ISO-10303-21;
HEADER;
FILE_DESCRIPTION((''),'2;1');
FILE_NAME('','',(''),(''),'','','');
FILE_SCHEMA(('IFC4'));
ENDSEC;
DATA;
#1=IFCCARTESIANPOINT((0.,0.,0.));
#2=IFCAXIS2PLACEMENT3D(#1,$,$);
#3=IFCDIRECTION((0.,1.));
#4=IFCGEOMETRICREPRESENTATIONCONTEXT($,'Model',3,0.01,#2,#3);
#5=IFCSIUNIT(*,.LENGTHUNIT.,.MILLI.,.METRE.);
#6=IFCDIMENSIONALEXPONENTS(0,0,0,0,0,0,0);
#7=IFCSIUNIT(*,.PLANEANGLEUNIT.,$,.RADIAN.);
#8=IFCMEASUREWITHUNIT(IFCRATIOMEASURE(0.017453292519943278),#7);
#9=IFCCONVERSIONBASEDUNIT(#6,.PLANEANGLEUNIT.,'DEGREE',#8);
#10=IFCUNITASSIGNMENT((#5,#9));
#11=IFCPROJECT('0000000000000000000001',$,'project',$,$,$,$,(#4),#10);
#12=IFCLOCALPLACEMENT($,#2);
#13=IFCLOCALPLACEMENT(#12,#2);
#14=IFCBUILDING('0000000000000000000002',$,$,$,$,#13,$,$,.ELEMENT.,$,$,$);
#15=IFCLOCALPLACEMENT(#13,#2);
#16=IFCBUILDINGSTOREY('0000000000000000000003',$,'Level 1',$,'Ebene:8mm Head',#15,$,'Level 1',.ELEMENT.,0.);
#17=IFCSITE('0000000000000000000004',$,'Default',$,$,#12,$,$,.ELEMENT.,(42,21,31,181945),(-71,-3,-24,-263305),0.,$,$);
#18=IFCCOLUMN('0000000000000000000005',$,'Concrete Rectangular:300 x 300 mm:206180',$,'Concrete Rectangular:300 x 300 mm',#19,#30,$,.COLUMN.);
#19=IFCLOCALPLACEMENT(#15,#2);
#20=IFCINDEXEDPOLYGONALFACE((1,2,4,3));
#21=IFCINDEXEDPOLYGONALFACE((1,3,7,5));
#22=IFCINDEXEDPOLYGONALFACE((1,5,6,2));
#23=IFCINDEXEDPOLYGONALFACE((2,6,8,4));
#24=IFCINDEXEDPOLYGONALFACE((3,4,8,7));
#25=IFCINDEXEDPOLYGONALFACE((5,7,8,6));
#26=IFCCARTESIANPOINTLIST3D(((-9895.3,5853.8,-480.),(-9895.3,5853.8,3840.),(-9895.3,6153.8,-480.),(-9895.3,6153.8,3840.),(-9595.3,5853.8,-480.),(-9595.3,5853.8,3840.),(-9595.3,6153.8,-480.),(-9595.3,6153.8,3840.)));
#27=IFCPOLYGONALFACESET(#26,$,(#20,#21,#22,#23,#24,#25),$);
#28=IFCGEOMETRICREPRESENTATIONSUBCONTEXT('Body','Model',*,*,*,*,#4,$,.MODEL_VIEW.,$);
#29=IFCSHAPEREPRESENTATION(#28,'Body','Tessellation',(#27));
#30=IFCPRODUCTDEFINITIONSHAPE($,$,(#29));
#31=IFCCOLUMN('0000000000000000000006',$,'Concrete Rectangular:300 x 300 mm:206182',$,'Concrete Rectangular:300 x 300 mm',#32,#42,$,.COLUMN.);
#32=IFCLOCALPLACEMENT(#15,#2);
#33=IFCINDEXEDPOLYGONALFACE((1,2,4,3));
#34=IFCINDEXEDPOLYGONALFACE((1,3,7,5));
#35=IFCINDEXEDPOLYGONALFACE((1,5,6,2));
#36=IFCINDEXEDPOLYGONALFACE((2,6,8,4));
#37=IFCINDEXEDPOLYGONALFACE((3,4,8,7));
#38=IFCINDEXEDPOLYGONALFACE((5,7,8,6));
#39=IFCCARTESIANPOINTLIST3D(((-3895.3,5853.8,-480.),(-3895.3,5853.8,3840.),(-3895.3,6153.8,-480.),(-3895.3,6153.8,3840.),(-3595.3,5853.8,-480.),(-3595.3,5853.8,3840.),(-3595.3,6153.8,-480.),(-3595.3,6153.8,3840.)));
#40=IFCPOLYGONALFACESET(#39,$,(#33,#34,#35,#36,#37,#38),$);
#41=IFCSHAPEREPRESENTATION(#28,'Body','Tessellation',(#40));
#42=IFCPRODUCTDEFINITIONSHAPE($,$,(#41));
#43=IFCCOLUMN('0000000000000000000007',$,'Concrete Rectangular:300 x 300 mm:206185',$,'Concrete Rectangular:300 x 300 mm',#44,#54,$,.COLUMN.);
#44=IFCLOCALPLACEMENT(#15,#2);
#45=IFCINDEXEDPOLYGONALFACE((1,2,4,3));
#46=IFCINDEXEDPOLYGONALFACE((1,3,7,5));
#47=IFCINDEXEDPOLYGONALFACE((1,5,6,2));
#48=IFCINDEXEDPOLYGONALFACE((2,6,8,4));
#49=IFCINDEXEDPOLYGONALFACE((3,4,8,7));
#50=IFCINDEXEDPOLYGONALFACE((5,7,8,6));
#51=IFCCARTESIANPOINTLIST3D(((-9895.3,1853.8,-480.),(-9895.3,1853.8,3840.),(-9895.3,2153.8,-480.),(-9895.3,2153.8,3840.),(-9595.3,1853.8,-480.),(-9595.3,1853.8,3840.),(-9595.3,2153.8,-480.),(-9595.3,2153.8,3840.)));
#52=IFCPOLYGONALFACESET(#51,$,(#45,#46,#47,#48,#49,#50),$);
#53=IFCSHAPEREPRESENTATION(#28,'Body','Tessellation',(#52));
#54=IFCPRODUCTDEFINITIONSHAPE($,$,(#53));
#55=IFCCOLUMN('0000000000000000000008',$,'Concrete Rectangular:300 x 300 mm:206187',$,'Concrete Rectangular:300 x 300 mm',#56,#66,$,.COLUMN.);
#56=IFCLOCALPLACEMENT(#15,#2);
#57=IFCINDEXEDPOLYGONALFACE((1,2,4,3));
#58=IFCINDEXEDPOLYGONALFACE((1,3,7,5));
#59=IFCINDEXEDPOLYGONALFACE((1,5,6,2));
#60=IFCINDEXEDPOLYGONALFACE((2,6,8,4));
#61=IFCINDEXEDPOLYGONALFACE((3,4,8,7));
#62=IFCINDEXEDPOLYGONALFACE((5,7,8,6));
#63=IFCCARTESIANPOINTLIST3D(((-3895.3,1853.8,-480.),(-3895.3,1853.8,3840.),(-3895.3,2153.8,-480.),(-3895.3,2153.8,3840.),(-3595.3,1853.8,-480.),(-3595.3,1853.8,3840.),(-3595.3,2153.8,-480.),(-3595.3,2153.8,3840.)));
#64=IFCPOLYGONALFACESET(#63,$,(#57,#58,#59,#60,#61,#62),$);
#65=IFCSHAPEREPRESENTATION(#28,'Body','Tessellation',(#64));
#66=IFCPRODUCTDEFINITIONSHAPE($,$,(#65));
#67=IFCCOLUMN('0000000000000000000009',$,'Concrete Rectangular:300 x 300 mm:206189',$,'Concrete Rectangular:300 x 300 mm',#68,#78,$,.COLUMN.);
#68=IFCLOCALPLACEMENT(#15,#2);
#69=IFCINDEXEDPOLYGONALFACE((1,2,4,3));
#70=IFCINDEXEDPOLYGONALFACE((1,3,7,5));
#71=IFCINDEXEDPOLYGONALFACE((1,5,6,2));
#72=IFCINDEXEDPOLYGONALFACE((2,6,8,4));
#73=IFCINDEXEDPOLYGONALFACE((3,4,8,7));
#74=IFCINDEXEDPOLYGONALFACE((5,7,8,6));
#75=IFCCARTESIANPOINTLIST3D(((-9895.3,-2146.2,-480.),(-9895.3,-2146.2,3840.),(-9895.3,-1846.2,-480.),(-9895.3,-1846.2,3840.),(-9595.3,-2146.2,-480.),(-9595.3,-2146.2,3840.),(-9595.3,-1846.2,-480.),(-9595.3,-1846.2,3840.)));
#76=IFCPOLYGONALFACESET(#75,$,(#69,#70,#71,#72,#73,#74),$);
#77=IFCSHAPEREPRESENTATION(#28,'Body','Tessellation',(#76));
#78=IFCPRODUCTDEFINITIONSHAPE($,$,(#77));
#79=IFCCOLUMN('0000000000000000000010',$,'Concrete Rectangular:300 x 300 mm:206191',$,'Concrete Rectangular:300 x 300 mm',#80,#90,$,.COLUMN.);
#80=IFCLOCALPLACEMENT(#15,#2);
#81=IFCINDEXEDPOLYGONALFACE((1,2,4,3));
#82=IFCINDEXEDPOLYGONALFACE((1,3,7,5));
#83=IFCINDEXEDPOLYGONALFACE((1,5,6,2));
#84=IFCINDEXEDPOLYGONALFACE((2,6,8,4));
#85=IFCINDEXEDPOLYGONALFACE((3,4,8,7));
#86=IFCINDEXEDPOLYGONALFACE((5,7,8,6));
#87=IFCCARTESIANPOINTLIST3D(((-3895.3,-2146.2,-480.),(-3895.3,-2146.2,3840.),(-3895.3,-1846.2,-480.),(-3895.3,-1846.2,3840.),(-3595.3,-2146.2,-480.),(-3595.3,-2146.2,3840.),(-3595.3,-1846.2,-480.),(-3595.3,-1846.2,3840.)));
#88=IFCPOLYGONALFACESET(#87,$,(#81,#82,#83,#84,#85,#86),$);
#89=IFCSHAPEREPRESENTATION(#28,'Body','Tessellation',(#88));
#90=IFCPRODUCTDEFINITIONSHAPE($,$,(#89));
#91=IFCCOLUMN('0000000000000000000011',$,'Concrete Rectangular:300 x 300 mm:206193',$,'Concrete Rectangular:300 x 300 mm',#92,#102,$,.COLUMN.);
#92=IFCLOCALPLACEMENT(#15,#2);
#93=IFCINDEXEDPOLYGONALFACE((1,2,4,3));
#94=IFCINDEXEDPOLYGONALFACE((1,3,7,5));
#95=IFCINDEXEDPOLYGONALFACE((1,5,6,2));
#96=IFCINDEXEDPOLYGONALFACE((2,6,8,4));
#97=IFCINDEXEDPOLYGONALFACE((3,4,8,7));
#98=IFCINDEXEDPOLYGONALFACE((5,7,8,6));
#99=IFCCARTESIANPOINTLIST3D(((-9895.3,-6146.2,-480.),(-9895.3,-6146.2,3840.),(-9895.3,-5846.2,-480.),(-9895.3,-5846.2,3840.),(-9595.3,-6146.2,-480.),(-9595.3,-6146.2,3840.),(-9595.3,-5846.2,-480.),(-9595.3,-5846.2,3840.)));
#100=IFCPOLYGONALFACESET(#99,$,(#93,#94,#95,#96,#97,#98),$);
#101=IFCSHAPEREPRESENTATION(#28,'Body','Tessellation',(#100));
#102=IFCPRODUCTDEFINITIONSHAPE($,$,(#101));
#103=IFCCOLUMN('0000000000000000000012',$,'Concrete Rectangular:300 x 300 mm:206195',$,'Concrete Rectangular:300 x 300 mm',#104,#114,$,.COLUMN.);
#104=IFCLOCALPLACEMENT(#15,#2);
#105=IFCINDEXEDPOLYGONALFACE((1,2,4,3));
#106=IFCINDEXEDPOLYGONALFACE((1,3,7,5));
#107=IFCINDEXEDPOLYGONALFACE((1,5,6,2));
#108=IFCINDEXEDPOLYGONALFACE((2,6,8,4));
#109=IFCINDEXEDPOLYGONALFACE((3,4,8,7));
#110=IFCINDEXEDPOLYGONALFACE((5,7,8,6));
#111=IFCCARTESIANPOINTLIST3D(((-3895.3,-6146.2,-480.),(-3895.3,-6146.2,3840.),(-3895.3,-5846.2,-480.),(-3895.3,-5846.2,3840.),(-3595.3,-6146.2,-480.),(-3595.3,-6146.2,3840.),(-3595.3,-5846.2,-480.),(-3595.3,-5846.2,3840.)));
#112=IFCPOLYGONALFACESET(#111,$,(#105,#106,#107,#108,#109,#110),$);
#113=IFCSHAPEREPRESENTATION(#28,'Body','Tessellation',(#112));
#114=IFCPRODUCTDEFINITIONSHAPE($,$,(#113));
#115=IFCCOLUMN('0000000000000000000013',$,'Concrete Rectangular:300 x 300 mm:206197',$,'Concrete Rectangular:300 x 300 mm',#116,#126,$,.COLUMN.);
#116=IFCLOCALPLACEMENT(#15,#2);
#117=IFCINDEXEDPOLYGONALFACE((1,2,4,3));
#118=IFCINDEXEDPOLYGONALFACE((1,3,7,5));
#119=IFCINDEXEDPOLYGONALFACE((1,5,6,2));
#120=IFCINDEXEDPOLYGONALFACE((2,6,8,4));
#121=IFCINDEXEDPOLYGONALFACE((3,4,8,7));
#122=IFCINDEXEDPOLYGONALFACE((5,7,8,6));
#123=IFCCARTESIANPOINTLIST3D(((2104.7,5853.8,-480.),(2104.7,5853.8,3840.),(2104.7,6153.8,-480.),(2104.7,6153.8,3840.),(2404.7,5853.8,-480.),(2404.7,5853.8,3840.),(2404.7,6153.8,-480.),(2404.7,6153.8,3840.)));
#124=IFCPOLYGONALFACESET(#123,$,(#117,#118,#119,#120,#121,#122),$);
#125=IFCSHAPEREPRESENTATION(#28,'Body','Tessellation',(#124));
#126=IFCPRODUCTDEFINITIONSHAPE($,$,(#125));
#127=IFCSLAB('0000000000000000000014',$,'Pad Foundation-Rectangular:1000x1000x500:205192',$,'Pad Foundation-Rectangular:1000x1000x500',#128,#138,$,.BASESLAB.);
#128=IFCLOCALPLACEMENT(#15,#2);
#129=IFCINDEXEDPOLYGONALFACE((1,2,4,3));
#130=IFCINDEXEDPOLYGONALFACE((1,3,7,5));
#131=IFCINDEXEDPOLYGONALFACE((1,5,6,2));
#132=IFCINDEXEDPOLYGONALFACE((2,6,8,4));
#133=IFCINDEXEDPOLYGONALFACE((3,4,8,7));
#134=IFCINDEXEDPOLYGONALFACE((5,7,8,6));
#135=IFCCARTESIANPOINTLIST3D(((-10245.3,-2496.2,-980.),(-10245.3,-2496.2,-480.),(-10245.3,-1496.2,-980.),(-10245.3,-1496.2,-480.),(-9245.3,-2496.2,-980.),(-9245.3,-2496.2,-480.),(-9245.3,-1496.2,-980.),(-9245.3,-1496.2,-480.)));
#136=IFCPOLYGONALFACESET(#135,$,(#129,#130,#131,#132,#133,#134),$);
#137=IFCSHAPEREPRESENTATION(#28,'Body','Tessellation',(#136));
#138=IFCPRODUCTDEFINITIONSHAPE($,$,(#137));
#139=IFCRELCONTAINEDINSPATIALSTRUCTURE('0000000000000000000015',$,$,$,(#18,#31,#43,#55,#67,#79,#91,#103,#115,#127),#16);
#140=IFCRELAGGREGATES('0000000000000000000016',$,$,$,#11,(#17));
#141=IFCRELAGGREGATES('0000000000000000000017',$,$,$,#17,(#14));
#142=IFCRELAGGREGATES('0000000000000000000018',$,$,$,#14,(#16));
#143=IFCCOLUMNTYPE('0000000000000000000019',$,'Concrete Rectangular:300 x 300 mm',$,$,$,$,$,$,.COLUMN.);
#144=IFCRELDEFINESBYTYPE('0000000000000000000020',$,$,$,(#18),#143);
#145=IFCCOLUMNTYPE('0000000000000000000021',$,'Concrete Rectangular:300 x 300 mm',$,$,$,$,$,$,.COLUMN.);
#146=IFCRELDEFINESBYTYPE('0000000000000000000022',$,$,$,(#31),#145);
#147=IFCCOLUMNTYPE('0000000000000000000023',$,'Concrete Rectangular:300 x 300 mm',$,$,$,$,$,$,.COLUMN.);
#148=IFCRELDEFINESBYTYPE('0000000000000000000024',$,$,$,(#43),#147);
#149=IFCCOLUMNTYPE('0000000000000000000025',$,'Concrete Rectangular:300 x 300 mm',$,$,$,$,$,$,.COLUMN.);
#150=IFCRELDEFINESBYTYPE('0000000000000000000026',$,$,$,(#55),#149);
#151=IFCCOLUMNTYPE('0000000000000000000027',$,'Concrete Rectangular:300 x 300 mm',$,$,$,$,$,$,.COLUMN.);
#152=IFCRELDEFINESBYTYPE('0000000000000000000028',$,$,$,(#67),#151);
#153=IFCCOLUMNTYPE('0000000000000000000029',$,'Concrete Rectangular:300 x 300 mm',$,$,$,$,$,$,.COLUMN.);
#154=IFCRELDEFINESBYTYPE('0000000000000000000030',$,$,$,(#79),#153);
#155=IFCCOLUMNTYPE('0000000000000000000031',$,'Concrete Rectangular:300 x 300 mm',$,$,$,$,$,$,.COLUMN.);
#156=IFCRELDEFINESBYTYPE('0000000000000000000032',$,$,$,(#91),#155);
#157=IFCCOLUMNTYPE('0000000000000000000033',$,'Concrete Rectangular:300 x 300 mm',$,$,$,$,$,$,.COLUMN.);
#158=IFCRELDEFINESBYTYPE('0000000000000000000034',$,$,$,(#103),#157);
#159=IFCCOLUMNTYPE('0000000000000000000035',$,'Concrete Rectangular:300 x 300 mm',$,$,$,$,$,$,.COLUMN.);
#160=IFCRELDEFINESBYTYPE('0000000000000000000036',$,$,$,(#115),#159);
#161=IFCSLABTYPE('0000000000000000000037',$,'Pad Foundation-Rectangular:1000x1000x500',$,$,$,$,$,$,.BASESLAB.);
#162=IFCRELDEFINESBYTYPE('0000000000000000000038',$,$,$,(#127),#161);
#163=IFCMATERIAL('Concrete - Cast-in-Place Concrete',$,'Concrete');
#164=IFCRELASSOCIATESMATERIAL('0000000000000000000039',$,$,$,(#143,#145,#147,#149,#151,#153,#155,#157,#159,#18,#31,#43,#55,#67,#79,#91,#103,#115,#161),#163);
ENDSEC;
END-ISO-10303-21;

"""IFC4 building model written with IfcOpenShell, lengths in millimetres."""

from ifc_helpers import new_model, entity, si_unit, converted_unit, direction, frame, frame_2d, origin, origin_2d_with_axis, place, context, subcontext, project, spatial, polyline, segment, composite_curve, rectangle, outline, extrude, source, transform, mapped, material, material_profile, profile_set, profile_usage, type_object, type_shapes, element, save


model = new_model("IFC4")

# Units and contexts
model_context = context("Model", 3, precision=0.01, world=origin(), true_north=direction((0.0, 1.0)))
body_context = subcontext(model_context, "Body", "Model", "MODEL_VIEW")
ifc_project = project(units=[si_unit("LENGTHUNIT", "METRE", prefix="MILLI"), converted_unit("PLANEANGLEUNIT", "DEGREE", entity("IfcRatioMeasure", 0.017453292519943278), si_unit("PLANEANGLEUNIT", "RADIAN"), dimensions=[0, 0, 0, 0, 0, 0, 0])], contexts=[model_context])

# Site, building, storey
site_placement = place(None, origin())
site = spatial("IfcSite", under=ifc_project, at=site_placement, Name="Default", CompositionType="ELEMENT", RefLatitude=(42, 21, 31, 181945), RefLongitude=(-71, -3, -24, -263305), RefElevation=0.0)
building_placement = place(site_placement, origin())
building = spatial("IfcBuilding", under=site, at=building_placement, CompositionType="ELEMENT")
storey_placement = place(building_placement, origin())
storey = spatial("IfcBuildingStorey", under=building, at=storey_placement, Name="Level 1", ObjectType="Ebene:8mm Head", LongName="Level 1", CompositionType="ELEMENT", Elevation=0.0)

# Columns
ifc_material_1 = material(Name="Concrete - Cast-in-Place Concrete", Category="Concrete")
ifc_material_profile_1 = material_profile(ifc_material_1, outline(composite_curve([segment(polyline([(150.0, 150.0, 0.0), (150.0, -150.0, 0.0)]), True, "CONTINUOUS"), segment(polyline([(150.0, -150.0, 0.0), (-150.0, -150.0, 0.0)]), True, "CONTINUOUS"), segment(polyline([(-150.0, -150.0, 0.0), (-150.0, 150.0, 0.0)]), True, "CONTINUOUS"), segment(polyline([(-150.0, 150.0, 0.0), (150.0, 150.0, 0.0)]), True, "CONTINUOUS")], self_intersect=False), kind="CURVE"), Name="300 x 300 mm")
ifc_material_profile_2 = material_profile(ifc_material_1, outline(composite_curve([segment(polyline([(150.0, 150.0, 4000.0), (-150.0, 150.0, 4000.0)]), True, "CONTINUOUS"), segment(polyline([(-150.0, 150.0, 4000.0), (-150.0, -150.0, 4000.0)]), True, "CONTINUOUS"), segment(polyline([(-150.0, -150.0, 4000.0), (150.0, -150.0, 4000.0)]), True, "CONTINUOUS"), segment(polyline([(150.0, -150.0, 4000.0), (150.0, 150.0, 4000.0)]), True, "CONTINUOUS")], self_intersect=False), kind="CURVE"), Name="300 x 300 mm")
ifc_profile_set = profile_set([ifc_material_profile_1, ifc_material_profile_2], Name="300 x 300 mm")
ifc_profile_usage_1 = profile_usage(ifc_profile_set)
column_type_1 = type_object("IfcColumnType", Name="Concrete Rectangular:300 x 300 mm", PredefinedType="COLUMN", material=ifc_profile_set)
shared_shape_1 = source(origin(), body_context, "Body", "SweptSolid", [
    extrude(rectangle(XDim=300.0, YDim=300.0, at=frame_2d((0.0, 0.0), x_axis=(1.0, 0.0))), frame((-9745.3, 6003.8, -480.0), z_axis=(0.0, 0.0, 1.0), x_axis=(0.0, -1.0, 0.0)), (0.0, 0.0, 1.0), 4320.0),
])
type_shapes(column_type_1, [shared_shape_1])
column_1_placement = place(storey_placement, origin())
element("IfcColumn", 1, at=column_1_placement, inside=storey, type_object=column_type_1, material=ifc_profile_usage_1, Name="Concrete Rectangular:300 x 300 mm:206180", ObjectType="Concrete Rectangular:300 x 300 mm", PredefinedType="COLUMN", context=body_context, shape_type="MappedRepresentation", body=[
    mapped(shared_shape_1, transform((0.0, 0.0, 0.0), scale=1.0)),
])
ifc_profile_usage_2 = profile_usage(ifc_profile_set)
column_type_2 = type_object("IfcColumnType", Name="Concrete Rectangular:300 x 300 mm", PredefinedType="COLUMN", material=ifc_profile_set)
shared_shape_2 = source(origin(), body_context, "Body", "SweptSolid", [
    extrude(rectangle(XDim=300.0, YDim=300.0, at=frame_2d((0.0, 0.0), x_axis=(1.0, 0.0))), frame((-3745.3, 6003.8, -480.0), z_axis=(0.0, 0.0, 1.0), x_axis=(0.0, -1.0, 0.0)), (0.0, 0.0, 1.0), 4320.0),
])
type_shapes(column_type_2, [shared_shape_2])
column_2_placement = place(storey_placement, origin())
element("IfcColumn", 2, at=column_2_placement, inside=storey, type_object=column_type_2, material=ifc_profile_usage_2, Name="Concrete Rectangular:300 x 300 mm:206182", ObjectType="Concrete Rectangular:300 x 300 mm", PredefinedType="COLUMN", context=body_context, shape_type="MappedRepresentation", body=[
    mapped(shared_shape_2, transform((0.0, 0.0, 0.0), scale=1.0)),
])
ifc_profile_usage_3 = profile_usage(ifc_profile_set)
column_type_3 = type_object("IfcColumnType", Name="Concrete Rectangular:300 x 300 mm", PredefinedType="COLUMN", material=ifc_profile_set)
shared_shape_3 = source(origin(), body_context, "Body", "SweptSolid", [
    extrude(rectangle(XDim=300.0, YDim=300.0, at=frame_2d((0.0, 0.0), x_axis=(1.0, 0.0))), frame((-9745.3, 2003.8, -480.0), z_axis=(0.0, 0.0, 1.0), x_axis=(0.0, -1.0, 0.0)), (0.0, 0.0, 1.0), 4320.0),
])
type_shapes(column_type_3, [shared_shape_3])
column_3_placement = place(storey_placement, origin())
element("IfcColumn", 3, at=column_3_placement, inside=storey, type_object=column_type_3, material=ifc_profile_usage_3, Name="Concrete Rectangular:300 x 300 mm:206185", ObjectType="Concrete Rectangular:300 x 300 mm", PredefinedType="COLUMN", context=body_context, shape_type="MappedRepresentation", body=[
    mapped(shared_shape_3, transform((0.0, 0.0, 0.0), scale=1.0)),
])
ifc_profile_usage_4 = profile_usage(ifc_profile_set)
column_type_4 = type_object("IfcColumnType", Name="Concrete Rectangular:300 x 300 mm", PredefinedType="COLUMN", material=ifc_profile_set)
shared_shape_4 = source(origin(), body_context, "Body", "SweptSolid", [
    extrude(rectangle(XDim=300.0, YDim=300.0, at=origin_2d_with_axis()), frame((-3745.3, 2003.8, -480.0), z_axis=(0.0, 0.0, 1.0), x_axis=(0.0, -1.0, 0.0)), (0.0, 0.0, 1.0), 4320.0),
])
type_shapes(column_type_4, [shared_shape_4])
column_4_placement = place(storey_placement, origin())
element("IfcColumn", 4, at=column_4_placement, inside=storey, type_object=column_type_4, material=ifc_profile_usage_4, Name="Concrete Rectangular:300 x 300 mm:206187", ObjectType="Concrete Rectangular:300 x 300 mm", PredefinedType="COLUMN", context=body_context, shape_type="MappedRepresentation", body=[
    mapped(shared_shape_4, transform((0.0, 0.0, 0.0), scale=1.0)),
])
ifc_profile_usage_5 = profile_usage(ifc_profile_set)
column_type_5 = type_object("IfcColumnType", Name="Concrete Rectangular:300 x 300 mm", PredefinedType="COLUMN", material=ifc_profile_set)
shared_shape_5 = source(origin(), body_context, "Body", "SweptSolid", [
    extrude(rectangle(XDim=300.0, YDim=300.0, at=frame_2d((0.0, 0.0), x_axis=(1.0, 0.0))), frame((-9745.3, -1996.2, -480.0), z_axis=(0.0, 0.0, 1.0), x_axis=(0.0, -1.0, 0.0)), (0.0, 0.0, 1.0), 4320.0),
])
type_shapes(column_type_5, [shared_shape_5])
column_5_placement = place(storey_placement, origin())
element("IfcColumn", 5, at=column_5_placement, inside=storey, type_object=column_type_5, material=ifc_profile_usage_5, Name="Concrete Rectangular:300 x 300 mm:206189", ObjectType="Concrete Rectangular:300 x 300 mm", PredefinedType="COLUMN", context=body_context, shape_type="MappedRepresentation", body=[
    mapped(shared_shape_5, transform((0.0, 0.0, 0.0), scale=1.0)),
])
ifc_profile_usage_6 = profile_usage(ifc_profile_set)
column_type_6 = type_object("IfcColumnType", Name="Concrete Rectangular:300 x 300 mm", PredefinedType="COLUMN", material=ifc_profile_set)
shared_shape_6 = source(origin(), body_context, "Body", "SweptSolid", [
    extrude(rectangle(XDim=300.0, YDim=300.0, at=origin_2d_with_axis()), frame((-3745.3, -1996.2, -480.0), z_axis=(0.0, 0.0, 1.0), x_axis=(0.0, -1.0, 0.0)), (0.0, 0.0, 1.0), 4320.0),
])
type_shapes(column_type_6, [shared_shape_6])
column_6_placement = place(storey_placement, origin())
element("IfcColumn", 6, at=column_6_placement, inside=storey, type_object=column_type_6, material=ifc_profile_usage_6, Name="Concrete Rectangular:300 x 300 mm:206191", ObjectType="Concrete Rectangular:300 x 300 mm", PredefinedType="COLUMN", context=body_context, shape_type="MappedRepresentation", body=[
    mapped(shared_shape_6, transform((0.0, 0.0, 0.0), scale=1.0)),
])
ifc_profile_usage_7 = profile_usage(ifc_profile_set)
column_type_7 = type_object("IfcColumnType", Name="Concrete Rectangular:300 x 300 mm", PredefinedType="COLUMN", material=ifc_profile_set)
shared_shape_7 = source(origin(), body_context, "Body", "SweptSolid", [
    extrude(rectangle(XDim=300.0, YDim=300.0, at=frame_2d((0.0, 0.0), x_axis=(1.0, 0.0))), frame((-9745.3, -5996.2, -480.0), z_axis=(0.0, 0.0, 1.0), x_axis=(0.0, -1.0, 0.0)), (0.0, 0.0, 1.0), 4320.0),
])
type_shapes(column_type_7, [shared_shape_7])
column_7_placement = place(storey_placement, origin())
element("IfcColumn", 7, at=column_7_placement, inside=storey, type_object=column_type_7, material=ifc_profile_usage_7, Name="Concrete Rectangular:300 x 300 mm:206193", ObjectType="Concrete Rectangular:300 x 300 mm", PredefinedType="COLUMN", context=body_context, shape_type="MappedRepresentation", body=[
    mapped(shared_shape_7, transform((0.0, 0.0, 0.0), scale=1.0)),
])
ifc_profile_usage_8 = profile_usage(ifc_profile_set)
column_type_8 = type_object("IfcColumnType", Name="Concrete Rectangular:300 x 300 mm", PredefinedType="COLUMN", material=ifc_profile_set)
shared_shape_8 = source(origin(), body_context, "Body", "SweptSolid", [
    extrude(rectangle(XDim=300.0, YDim=300.0, at=frame_2d((0.0, 0.0), x_axis=(1.0, 0.0))), frame((-3745.3, -5996.2, -480.0), z_axis=(0.0, 0.0, 1.0), x_axis=(0.0, -1.0, 0.0)), (0.0, 0.0, 1.0), 4320.0),
])
type_shapes(column_type_8, [shared_shape_8])
column_8_placement = place(storey_placement, origin())
element("IfcColumn", 8, at=column_8_placement, inside=storey, type_object=column_type_8, material=ifc_profile_usage_8, Name="Concrete Rectangular:300 x 300 mm:206195", ObjectType="Concrete Rectangular:300 x 300 mm", PredefinedType="COLUMN", context=body_context, shape_type="MappedRepresentation", body=[
    mapped(shared_shape_8, transform((0.0, 0.0, 0.0), scale=1.0)),
])
ifc_profile_usage_9 = profile_usage(ifc_profile_set)
column_type_9 = type_object("IfcColumnType", Name="Concrete Rectangular:300 x 300 mm", PredefinedType="COLUMN", material=ifc_profile_set)
shared_shape_9 = source(origin(), body_context, "Body", "SweptSolid", [
    extrude(rectangle(XDim=300.0, YDim=300.0, at=frame_2d((0.0, 0.0), x_axis=(1.0, 0.0))), frame((2254.7, 6003.8, -480.0), z_axis=(0.0, 0.0, 1.0), x_axis=(0.0, -1.0, 0.0)), (0.0, 0.0, 1.0), 4320.0),
])
type_shapes(column_type_9, [shared_shape_9])
column_9_placement = place(storey_placement, origin())
element("IfcColumn", 9, at=column_9_placement, inside=storey, type_object=column_type_9, material=ifc_profile_usage_9, Name="Concrete Rectangular:300 x 300 mm:206197", ObjectType="Concrete Rectangular:300 x 300 mm", PredefinedType="COLUMN", context=body_context, shape_type="MappedRepresentation", body=[
    mapped(shared_shape_9, transform((0.0, 0.0, 0.0), scale=1.0)),
])

# Slab
slab_type_1 = type_object("IfcSlabType", Name="Pad Foundation-Rectangular:1000x1000x500", PredefinedType="BASESLAB", material=ifc_material_1)
slab_1_placement = place(storey_placement, frame((-10245.3, -2496.2, -980.0)))
element("IfcSlab", 10, at=slab_1_placement, inside=storey, type_object=slab_type_1, Name="Pad Foundation-Rectangular:1000x1000x500:205192", ObjectType="Pad Foundation-Rectangular:1000x1000x500", PredefinedType="BASESLAB", context=body_context, shape_type="SweptSolid", body=[
    extrude(rectangle(XDim=1000.0, YDim=1000.0, at=frame_2d((0.0, 0.0), x_axis=(1.0, 0.0))), frame((500.0, 500.0, 0.0), z_axis=(0.0, 0.0, 1.0), x_axis=(-1.0, 0.0, 0.0)), (0.0, 0.0, 1.0), 500.0),
])

save(model, "model.ifc")
